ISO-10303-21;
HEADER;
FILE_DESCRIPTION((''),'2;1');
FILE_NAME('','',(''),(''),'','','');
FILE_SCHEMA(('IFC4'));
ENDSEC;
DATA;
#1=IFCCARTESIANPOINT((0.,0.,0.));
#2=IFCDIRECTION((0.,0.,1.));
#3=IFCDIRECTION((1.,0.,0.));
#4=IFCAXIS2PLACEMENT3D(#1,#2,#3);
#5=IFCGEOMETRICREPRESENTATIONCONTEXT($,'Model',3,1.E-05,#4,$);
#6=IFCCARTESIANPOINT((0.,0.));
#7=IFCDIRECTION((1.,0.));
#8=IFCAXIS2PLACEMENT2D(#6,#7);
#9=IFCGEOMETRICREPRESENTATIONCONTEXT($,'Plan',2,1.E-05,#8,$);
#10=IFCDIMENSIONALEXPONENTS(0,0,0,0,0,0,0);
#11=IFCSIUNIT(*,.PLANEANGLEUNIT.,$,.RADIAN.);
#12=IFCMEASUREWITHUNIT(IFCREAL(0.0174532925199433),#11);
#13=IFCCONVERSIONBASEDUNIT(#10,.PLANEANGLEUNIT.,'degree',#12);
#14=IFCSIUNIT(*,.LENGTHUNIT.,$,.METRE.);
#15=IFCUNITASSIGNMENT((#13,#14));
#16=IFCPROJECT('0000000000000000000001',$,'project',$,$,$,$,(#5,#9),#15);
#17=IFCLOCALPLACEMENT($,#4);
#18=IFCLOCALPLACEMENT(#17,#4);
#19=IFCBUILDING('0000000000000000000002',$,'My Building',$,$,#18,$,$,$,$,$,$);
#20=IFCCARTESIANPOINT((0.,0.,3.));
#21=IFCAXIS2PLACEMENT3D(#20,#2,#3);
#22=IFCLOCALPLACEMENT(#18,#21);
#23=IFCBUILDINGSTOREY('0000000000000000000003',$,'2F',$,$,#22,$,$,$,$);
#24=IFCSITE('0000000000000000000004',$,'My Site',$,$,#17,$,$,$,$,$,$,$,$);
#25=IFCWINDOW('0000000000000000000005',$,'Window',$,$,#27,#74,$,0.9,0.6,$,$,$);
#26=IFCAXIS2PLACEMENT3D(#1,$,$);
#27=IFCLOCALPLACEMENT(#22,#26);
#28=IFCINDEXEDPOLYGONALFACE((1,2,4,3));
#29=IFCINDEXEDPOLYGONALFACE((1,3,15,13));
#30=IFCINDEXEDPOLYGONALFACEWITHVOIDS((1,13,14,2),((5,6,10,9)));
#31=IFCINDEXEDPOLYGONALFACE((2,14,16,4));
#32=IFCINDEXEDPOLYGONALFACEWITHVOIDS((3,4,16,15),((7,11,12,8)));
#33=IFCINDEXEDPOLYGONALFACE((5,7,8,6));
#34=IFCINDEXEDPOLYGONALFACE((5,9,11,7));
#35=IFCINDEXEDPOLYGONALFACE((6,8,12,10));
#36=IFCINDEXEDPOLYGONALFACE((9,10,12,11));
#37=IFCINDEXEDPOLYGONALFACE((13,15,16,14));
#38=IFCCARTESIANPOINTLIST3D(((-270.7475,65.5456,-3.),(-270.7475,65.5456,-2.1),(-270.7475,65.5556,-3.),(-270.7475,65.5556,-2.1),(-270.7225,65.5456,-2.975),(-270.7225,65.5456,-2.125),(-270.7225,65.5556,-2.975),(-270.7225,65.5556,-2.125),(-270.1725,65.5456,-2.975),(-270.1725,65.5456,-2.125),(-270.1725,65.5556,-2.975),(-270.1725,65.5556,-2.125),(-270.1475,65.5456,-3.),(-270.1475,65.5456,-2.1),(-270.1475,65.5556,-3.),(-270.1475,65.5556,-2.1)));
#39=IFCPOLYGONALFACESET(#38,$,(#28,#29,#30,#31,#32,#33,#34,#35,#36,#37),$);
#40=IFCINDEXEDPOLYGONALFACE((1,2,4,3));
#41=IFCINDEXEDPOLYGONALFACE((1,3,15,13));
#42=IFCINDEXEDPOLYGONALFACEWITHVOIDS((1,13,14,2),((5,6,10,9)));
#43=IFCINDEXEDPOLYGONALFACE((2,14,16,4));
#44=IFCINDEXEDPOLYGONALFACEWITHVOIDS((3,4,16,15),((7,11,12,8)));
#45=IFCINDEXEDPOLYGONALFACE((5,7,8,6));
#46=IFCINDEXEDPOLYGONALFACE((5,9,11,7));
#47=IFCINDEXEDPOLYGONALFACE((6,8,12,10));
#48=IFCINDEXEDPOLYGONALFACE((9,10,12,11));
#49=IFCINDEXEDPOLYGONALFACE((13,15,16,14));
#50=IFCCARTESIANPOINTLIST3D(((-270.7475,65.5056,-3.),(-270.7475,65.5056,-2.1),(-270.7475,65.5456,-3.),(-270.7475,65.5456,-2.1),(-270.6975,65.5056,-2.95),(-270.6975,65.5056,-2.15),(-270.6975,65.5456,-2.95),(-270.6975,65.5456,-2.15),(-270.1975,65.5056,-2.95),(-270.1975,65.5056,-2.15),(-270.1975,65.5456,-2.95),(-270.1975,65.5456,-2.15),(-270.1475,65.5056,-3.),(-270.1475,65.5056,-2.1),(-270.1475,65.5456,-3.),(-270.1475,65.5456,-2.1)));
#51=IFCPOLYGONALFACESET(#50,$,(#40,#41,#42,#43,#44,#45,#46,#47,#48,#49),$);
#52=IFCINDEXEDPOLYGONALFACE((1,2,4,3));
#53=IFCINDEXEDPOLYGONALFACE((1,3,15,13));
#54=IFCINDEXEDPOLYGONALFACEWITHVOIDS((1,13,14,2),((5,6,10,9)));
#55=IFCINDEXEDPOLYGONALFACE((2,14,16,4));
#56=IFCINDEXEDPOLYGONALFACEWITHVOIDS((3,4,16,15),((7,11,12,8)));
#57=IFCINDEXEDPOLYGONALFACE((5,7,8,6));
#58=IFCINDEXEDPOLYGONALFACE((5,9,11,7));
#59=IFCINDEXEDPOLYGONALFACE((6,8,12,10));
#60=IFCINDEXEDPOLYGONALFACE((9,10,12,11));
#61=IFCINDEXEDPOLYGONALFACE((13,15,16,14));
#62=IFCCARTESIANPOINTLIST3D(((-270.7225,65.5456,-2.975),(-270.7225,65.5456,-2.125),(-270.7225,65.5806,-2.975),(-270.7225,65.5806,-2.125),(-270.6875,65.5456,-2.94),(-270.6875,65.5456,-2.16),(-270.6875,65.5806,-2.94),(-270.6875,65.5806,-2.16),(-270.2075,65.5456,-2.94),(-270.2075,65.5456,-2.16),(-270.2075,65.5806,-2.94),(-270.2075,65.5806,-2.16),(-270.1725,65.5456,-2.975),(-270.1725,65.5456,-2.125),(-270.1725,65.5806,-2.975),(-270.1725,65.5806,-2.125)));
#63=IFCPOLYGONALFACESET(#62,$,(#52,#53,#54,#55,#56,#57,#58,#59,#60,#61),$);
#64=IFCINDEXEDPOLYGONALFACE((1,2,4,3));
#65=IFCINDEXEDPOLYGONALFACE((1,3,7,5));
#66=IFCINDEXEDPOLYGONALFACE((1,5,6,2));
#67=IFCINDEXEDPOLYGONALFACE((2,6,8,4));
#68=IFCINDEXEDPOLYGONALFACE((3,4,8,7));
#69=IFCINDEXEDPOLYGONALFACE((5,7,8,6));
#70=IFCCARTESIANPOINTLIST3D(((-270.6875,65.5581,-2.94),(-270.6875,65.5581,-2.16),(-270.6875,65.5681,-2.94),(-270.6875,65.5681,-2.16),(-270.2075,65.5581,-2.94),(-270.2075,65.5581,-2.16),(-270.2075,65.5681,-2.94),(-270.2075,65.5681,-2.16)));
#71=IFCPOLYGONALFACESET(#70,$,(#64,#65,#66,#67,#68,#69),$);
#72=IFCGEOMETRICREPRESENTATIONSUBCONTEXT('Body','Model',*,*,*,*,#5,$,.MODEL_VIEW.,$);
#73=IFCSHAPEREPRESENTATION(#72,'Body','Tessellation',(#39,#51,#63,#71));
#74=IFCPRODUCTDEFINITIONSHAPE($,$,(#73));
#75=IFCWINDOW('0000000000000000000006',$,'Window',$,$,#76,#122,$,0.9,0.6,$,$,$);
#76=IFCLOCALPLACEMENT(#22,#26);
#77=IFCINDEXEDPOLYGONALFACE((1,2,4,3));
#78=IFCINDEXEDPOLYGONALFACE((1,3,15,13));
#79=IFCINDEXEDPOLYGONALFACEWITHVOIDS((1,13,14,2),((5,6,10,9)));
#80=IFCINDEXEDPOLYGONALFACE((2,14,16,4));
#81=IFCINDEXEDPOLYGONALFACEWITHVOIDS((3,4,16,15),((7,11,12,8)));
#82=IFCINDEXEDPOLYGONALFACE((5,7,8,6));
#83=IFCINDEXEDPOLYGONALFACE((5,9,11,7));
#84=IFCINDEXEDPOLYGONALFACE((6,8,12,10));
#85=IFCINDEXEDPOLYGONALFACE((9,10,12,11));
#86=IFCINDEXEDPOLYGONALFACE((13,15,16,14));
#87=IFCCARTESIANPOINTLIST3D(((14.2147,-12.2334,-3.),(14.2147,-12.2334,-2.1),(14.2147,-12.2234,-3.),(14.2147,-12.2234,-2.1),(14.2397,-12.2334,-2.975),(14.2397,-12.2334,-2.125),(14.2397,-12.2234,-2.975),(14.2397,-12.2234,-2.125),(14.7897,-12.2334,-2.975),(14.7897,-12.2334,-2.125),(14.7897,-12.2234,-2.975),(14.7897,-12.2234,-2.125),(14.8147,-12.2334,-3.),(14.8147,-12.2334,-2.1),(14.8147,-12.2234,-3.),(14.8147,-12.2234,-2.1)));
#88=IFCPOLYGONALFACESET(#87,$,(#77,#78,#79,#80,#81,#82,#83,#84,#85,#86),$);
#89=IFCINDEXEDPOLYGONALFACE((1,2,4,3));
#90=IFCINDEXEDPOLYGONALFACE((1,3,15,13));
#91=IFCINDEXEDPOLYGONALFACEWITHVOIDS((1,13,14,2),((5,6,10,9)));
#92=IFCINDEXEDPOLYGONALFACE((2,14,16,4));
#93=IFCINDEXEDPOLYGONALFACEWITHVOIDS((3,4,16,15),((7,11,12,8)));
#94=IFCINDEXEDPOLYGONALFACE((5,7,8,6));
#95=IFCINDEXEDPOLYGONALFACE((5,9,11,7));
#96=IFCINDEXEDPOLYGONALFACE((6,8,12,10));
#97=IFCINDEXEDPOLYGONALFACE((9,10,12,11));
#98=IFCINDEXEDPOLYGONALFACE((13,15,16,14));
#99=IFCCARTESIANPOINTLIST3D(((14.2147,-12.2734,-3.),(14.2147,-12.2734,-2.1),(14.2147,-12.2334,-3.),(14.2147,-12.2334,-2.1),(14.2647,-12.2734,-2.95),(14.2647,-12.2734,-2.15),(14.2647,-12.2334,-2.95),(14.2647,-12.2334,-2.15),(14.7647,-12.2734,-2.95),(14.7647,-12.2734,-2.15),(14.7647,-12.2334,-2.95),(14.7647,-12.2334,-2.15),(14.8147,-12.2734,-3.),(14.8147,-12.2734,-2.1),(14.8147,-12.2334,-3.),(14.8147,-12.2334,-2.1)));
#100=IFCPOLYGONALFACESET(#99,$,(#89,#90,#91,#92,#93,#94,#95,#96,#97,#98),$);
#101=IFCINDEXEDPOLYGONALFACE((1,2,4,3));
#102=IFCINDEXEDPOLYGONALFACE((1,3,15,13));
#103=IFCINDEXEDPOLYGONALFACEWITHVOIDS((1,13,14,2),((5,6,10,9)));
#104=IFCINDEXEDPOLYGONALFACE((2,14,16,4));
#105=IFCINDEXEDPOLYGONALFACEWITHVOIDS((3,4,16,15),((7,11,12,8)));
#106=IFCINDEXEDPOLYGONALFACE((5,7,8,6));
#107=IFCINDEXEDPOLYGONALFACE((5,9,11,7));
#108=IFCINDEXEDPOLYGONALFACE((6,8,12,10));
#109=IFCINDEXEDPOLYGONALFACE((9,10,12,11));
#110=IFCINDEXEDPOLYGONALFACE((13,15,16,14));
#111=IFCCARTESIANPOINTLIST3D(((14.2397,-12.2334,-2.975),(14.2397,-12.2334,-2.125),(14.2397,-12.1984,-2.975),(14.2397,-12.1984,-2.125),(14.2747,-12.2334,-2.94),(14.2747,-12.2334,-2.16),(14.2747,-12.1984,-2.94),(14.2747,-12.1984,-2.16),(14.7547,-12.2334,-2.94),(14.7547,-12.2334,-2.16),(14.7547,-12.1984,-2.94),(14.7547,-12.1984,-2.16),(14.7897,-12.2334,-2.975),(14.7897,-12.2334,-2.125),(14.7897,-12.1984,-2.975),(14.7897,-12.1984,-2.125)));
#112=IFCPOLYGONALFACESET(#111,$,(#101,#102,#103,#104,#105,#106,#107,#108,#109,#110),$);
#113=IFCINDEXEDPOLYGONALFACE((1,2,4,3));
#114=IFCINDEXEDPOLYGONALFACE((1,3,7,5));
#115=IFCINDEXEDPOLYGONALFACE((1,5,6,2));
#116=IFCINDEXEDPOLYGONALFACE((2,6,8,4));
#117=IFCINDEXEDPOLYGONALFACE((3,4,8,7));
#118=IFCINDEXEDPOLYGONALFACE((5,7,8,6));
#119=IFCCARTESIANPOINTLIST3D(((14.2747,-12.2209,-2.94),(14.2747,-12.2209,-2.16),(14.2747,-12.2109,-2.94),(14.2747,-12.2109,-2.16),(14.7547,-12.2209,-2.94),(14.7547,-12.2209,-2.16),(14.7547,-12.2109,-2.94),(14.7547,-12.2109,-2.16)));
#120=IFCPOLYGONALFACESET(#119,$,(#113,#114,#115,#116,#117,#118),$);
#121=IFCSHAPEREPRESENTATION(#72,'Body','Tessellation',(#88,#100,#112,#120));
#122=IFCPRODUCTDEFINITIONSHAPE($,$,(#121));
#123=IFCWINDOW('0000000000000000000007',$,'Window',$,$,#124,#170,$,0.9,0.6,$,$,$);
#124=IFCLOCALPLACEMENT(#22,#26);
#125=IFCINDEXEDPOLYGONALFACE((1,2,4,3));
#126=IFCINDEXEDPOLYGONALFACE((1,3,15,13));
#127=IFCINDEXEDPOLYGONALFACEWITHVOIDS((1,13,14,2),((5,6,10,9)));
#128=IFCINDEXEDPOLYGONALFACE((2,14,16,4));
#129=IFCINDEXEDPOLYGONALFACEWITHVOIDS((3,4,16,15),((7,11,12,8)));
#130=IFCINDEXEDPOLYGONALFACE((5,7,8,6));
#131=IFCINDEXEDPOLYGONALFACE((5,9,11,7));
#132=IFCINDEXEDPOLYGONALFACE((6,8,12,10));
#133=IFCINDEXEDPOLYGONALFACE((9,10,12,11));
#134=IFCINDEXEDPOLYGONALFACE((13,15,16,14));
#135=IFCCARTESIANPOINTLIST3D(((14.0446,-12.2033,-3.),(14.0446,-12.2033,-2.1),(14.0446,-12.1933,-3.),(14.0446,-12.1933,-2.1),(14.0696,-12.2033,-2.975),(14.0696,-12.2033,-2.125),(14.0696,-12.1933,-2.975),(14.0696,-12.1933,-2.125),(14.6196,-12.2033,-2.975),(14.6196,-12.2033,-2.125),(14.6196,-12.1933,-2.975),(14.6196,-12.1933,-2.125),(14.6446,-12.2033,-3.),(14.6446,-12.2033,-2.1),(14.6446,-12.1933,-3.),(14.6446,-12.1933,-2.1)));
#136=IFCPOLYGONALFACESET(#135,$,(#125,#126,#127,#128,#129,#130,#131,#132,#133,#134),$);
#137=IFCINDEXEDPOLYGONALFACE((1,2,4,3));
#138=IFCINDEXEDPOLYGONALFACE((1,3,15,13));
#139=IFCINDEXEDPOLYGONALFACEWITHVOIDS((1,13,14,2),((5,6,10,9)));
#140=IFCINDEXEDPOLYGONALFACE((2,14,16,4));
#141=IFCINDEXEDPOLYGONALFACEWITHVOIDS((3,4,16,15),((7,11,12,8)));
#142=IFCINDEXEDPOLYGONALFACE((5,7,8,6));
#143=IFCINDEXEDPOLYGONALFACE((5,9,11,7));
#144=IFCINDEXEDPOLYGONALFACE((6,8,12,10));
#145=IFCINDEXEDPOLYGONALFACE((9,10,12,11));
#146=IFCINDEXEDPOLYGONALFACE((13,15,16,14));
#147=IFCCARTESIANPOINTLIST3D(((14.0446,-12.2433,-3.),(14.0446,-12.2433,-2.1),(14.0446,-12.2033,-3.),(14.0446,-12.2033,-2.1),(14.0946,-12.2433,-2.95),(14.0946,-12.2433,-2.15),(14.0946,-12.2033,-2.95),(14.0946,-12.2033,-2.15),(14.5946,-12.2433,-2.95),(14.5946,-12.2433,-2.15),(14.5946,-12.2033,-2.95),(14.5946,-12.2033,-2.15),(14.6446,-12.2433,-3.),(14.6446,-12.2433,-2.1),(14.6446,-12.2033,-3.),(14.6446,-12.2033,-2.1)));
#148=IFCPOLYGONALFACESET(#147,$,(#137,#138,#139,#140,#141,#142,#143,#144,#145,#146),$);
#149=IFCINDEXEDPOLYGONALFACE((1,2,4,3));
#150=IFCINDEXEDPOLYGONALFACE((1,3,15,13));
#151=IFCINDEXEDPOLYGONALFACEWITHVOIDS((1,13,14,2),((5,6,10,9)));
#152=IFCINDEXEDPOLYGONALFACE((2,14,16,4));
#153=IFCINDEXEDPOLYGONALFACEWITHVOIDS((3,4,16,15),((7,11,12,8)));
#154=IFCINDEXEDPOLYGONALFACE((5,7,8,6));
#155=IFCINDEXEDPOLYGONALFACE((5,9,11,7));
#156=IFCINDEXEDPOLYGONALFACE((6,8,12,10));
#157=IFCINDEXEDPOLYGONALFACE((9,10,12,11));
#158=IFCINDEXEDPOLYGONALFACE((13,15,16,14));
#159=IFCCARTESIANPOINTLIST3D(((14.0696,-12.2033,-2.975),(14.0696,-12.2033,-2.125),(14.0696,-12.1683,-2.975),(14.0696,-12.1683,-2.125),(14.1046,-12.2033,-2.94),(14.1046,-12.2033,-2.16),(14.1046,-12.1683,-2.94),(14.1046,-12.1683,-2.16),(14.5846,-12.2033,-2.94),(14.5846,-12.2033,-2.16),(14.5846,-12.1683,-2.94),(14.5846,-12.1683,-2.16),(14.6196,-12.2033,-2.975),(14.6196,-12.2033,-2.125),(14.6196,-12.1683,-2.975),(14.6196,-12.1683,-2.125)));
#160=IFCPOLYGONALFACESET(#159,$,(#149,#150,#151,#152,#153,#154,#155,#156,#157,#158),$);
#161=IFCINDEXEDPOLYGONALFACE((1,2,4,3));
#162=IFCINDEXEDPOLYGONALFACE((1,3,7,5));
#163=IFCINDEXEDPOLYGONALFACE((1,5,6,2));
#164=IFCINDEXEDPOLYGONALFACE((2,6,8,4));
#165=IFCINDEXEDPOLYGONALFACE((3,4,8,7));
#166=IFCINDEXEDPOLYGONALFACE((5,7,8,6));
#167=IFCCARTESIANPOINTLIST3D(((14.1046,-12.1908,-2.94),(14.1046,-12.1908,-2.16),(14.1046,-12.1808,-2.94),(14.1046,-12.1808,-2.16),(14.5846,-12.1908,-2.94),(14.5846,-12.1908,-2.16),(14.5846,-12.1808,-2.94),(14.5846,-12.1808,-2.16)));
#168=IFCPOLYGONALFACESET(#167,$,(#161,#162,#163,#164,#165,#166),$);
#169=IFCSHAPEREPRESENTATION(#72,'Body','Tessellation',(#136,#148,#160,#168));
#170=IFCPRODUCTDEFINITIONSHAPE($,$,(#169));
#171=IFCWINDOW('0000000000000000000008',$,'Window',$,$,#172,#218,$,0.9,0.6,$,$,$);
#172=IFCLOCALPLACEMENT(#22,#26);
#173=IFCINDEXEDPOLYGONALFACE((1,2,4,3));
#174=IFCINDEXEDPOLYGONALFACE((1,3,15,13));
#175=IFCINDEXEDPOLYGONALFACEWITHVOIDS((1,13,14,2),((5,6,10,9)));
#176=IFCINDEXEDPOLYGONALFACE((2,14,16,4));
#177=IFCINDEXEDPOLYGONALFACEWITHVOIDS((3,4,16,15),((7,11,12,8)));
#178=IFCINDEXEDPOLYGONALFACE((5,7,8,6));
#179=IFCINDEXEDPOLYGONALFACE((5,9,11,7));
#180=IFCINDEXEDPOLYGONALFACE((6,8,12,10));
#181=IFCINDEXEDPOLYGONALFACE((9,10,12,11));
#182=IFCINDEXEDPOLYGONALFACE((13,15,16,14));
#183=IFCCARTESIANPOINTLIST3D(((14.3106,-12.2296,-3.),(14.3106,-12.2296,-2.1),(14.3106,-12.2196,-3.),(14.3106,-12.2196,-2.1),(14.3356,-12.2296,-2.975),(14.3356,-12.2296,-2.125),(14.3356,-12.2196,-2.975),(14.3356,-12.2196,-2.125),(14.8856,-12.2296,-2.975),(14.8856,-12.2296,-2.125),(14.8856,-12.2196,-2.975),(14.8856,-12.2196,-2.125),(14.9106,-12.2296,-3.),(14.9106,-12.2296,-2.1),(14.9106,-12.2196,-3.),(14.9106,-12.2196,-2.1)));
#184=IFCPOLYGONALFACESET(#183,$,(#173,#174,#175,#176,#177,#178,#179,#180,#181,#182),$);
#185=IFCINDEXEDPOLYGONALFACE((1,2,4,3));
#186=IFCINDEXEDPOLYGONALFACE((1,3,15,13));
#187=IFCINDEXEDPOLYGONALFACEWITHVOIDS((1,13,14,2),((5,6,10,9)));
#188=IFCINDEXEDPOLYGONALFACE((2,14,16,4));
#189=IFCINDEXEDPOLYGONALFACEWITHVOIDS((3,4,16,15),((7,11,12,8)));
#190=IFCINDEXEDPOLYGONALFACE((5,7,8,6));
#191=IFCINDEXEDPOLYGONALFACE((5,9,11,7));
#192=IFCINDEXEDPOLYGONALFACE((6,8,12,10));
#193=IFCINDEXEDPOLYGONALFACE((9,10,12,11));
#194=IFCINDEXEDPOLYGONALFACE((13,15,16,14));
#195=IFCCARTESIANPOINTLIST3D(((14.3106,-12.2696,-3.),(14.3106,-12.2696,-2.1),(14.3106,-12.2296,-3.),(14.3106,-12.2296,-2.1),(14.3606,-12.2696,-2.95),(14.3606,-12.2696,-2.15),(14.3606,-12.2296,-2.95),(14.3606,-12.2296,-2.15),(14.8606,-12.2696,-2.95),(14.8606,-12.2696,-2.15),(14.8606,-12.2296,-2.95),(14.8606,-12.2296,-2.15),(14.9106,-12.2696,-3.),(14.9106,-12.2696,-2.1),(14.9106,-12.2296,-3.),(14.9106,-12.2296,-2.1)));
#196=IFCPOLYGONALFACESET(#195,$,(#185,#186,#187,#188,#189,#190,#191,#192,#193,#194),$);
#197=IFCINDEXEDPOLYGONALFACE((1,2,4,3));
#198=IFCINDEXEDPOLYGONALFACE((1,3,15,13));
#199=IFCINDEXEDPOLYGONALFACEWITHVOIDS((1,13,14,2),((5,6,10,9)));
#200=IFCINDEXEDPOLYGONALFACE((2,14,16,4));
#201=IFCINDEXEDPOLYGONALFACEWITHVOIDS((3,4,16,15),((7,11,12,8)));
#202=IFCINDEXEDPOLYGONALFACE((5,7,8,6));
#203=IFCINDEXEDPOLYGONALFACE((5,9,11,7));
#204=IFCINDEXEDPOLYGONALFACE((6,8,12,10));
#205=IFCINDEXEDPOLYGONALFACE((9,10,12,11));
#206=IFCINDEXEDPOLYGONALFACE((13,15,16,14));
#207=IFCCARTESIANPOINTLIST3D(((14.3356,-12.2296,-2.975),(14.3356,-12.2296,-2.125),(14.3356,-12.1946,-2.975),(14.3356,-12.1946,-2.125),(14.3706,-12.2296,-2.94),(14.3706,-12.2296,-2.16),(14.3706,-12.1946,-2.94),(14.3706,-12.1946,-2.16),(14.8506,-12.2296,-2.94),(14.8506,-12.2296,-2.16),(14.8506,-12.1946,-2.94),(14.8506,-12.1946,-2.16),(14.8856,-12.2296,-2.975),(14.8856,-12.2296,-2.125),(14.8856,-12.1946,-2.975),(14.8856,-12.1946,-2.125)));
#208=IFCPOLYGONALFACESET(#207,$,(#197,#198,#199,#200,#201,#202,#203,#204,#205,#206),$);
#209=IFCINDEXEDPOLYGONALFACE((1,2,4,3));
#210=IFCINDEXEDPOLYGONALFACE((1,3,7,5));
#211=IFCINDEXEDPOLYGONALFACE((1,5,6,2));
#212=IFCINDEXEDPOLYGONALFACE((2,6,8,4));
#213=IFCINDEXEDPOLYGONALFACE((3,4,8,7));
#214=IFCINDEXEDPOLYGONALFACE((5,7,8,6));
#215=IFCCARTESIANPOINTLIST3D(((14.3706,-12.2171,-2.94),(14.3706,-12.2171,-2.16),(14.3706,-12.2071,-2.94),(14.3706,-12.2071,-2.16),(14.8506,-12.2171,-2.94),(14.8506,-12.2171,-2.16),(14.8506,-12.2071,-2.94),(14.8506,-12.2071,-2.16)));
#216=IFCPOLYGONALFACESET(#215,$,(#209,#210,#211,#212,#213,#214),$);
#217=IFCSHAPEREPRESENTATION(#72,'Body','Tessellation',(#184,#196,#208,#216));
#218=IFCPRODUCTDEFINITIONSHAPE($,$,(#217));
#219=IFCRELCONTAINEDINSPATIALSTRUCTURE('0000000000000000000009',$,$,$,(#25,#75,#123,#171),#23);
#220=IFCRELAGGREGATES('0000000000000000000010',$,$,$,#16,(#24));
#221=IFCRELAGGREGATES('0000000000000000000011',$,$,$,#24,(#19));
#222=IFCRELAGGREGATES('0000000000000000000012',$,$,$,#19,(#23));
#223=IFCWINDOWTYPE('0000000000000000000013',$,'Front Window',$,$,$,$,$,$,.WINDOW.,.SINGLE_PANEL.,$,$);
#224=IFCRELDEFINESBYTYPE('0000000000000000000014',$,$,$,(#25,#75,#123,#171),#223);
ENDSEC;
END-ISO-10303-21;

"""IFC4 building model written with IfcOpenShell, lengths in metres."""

from ifc_helpers import new_model, entity, si_unit, converted_unit, frame, origin_with_axes, origin_2d_with_axis, place, context, subcontext, project, spatial, line, indexed_curve, outline, extrude, shape, source, transform, mapped, type_object, type_shapes, element, save


model = new_model("IFC4")

# Units and contexts
model_context = context("Model", 3, precision=1e-05, world=origin_with_axes())
plan_context = context("Plan", 2, precision=1e-05, world=origin_2d_with_axis())
body_context_1 = subcontext(model_context, "Body", "Model", "MODEL_VIEW")
body_context_2 = subcontext(plan_context, "Body", "Plan", "PLAN_VIEW")
ifc_project = project(units=[converted_unit("PLANEANGLEUNIT", "degree", entity("IfcReal", 0.0174532925199433), si_unit("PLANEANGLEUNIT", "RADIAN"), dimensions=[0, 0, 0, 0, 0, 0, 0]), si_unit("LENGTHUNIT", "METRE")], contexts=[model_context, plan_context])

# Site, building, storey
site_placement = place(None, origin_with_axes())
site = spatial("IfcSite", under=ifc_project, at=site_placement, Name="My Site")
building_placement = place(site_placement, origin_with_axes())
building = spatial("IfcBuilding", under=site, at=building_placement, Name="My Building")
storey_placement = place(building_placement, frame((0.0, 0.0, 3.0), z_axis=(0.0, 0.0, 1.0), x_axis=(1.0, 0.0, 0.0)))
storey = spatial("IfcBuildingStorey", under=building, at=storey_placement, Name="2F")

# Windows
window_type_1 = type_object("IfcWindowType", Name="Front Window", PartitioningType="SINGLE_PANEL", PredefinedType="WINDOW")
shared_shape_1 = source(origin_with_axes(), body_context_1, "Body", "SweptSolid", [
    extrude(outline(indexed_curve([(0.0, 0.0), (0.6, 0.0), (0.6, 0.9), (0.0, 0.9)], segments=[line(1, 2, 3, 4, 1)]), holes=[indexed_curve([(0.025, 0.025), (0.575, 0.025), (0.575, 0.875), (0.025, 0.875)], segments=[line(1, 2, 3, 4, 1)])]), frame((0.0, 0.09, 0.0), z_axis=(0.0, -1.0, 0.0), x_axis=(1.0, 0.0, 0.0)), (0.0, 0.0, -1.0), 0.01),
    extrude(outline(indexed_curve([(0.0, 0.0), (0.6, 0.0), (0.6, 0.9), (0.0, 0.9)], segments=[line(1, 2, 3, 4, 1)]), holes=[indexed_curve([(0.05, 0.05), (0.55, 0.05), (0.55, 0.85), (0.05, 0.85)], segments=[line(1, 2, 3, 4, 1)])]), frame((0.0, 0.05, 0.0), z_axis=(0.0, -1.0, 0.0), x_axis=(1.0, 0.0, 0.0)), (0.0, 0.0, -1.0), 0.04),
    extrude(outline(indexed_curve([(0.0, 0.0), (0.55, 0.0), (0.55, 0.85), (0.0, 0.85)], segments=[line(1, 2, 3, 4, 1)]), holes=[indexed_curve([(0.035, 0.035), (0.515, 0.035), (0.515, 0.815), (0.035, 0.815)], segments=[line(1, 2, 3, 4, 1)])]), frame((0.025, 0.09, 0.025), z_axis=(0.0, -1.0, 0.0), x_axis=(1.0, 0.0, 0.0)), (0.0, 0.0, -1.0), 0.035),
    extrude(outline(indexed_curve([(0.035, 0.035), (0.515, 0.035), (0.515, 0.815), (0.035, 0.815)], segments=[line(1, 2, 3, 4, 1)])), frame((0.025, 0.1025, 0.025), z_axis=(0.0, -1.0, 0.0), x_axis=(1.0, 0.0, 0.0)), (0.0, 0.0, -1.0), 0.01),
])
shared_shape_2 = source(origin_with_axes(), body_context_2, "Body", "Curve2D", [
    entity("IfcIndexedPolyCurve", entity("IfcCartesianPointList2D", [[0.05, 0.05], [0.55, 0.05]])),
    entity("IfcIndexedPolyCurve", entity("IfcCartesianPointList2D", [[0.0, 0.1], [0.025, 0.1], [0.025, 0.09], [0.05, 0.09], [0.05, 0.05], [0.0, 0.05]]), [entity("IfcLineIndex", [1, 2, 3, 4, 5, 6, 1])]),
    entity("IfcIndexedPolyCurve", entity("IfcCartesianPointList2D", [[0.6, 0.1], [0.575, 0.1], [0.575, 0.09], [0.55, 0.09], [0.55, 0.05], [0.6, 0.05]]), [entity("IfcLineIndex", [1, 2, 3, 4, 5, 6, 1])]),
    entity("IfcIndexedPolyCurve", entity("IfcCartesianPointList2D", [[0.025, 0.09], [0.06, 0.09], [0.06, 0.125], [0.025, 0.125]]), [entity("IfcLineIndex", [1, 2, 3, 4, 1])]),
    entity("IfcIndexedPolyCurve", entity("IfcCartesianPointList2D", [[0.575, 0.09], [0.54, 0.09], [0.54, 0.125], [0.575, 0.125]]), [entity("IfcLineIndex", [1, 2, 3, 4, 1])]),
    entity("IfcIndexedPolyCurve", entity("IfcCartesianPointList2D", [[0.06, 0.09], [0.54, 0.09]])),
    entity("IfcIndexedPolyCurve", entity("IfcCartesianPointList2D", [[0.06, 0.125], [0.54, 0.125]])),
    entity("IfcIndexedPolyCurve", entity("IfcCartesianPointList2D", [[0.06, 0.1075], [0.54, 0.1075]])),
])
type_shapes(window_type_1, [shared_shape_1, shared_shape_2])
for number, where, z_axis, x_axis, name in (
    (1, (-270.7475, 65.4556, -3.0), (0.0, 0.0, 1.0), (1.0, 0.0, 0.0), "Window"),
    (2, (14.2147, -12.3234, -3.0), (0.0, 0.0, 1.0), (1.0, 0.0, 0.0), "Window"),
    (3, (14.0446, -12.2933, -3.0), (0.0, 0.0, 1.0), (1.0, 0.0, 0.0), "Window"),
    (4, (14.3106, -12.3196, -3.0), (0.0, 0.0, 1.0), (1.0, 0.0, 0.0), "Window"),
):
    element("IfcWindow", number, at=place(storey_placement, frame(where, z_axis=z_axis, x_axis=x_axis)), inside=storey, type_object=window_type_1, Name=name, OverallHeight=0.9, OverallWidth=0.6, shapes=[
        shape(body_context_1, "Body", "MappedRepresentation", [mapped(shared_shape_1, transform((0.0, 0.0, 0.0), x_axis=(1.0, 0.0, 0.0), y_axis=(0.0, 1.0, 0.0), z_axis=(0.0, 0.0, 1.0), scale=1.0))]),
        shape(body_context_2, "Body", "MappedRepresentation", [mapped(shared_shape_2, transform((0.0, 0.0, 0.0), x_axis=(1.0, 0.0, 0.0), y_axis=(0.0, 1.0, 0.0), z_axis=(0.0, 0.0, 1.0), scale=1.0))]),
    ])

save(model, "model.ifc")
